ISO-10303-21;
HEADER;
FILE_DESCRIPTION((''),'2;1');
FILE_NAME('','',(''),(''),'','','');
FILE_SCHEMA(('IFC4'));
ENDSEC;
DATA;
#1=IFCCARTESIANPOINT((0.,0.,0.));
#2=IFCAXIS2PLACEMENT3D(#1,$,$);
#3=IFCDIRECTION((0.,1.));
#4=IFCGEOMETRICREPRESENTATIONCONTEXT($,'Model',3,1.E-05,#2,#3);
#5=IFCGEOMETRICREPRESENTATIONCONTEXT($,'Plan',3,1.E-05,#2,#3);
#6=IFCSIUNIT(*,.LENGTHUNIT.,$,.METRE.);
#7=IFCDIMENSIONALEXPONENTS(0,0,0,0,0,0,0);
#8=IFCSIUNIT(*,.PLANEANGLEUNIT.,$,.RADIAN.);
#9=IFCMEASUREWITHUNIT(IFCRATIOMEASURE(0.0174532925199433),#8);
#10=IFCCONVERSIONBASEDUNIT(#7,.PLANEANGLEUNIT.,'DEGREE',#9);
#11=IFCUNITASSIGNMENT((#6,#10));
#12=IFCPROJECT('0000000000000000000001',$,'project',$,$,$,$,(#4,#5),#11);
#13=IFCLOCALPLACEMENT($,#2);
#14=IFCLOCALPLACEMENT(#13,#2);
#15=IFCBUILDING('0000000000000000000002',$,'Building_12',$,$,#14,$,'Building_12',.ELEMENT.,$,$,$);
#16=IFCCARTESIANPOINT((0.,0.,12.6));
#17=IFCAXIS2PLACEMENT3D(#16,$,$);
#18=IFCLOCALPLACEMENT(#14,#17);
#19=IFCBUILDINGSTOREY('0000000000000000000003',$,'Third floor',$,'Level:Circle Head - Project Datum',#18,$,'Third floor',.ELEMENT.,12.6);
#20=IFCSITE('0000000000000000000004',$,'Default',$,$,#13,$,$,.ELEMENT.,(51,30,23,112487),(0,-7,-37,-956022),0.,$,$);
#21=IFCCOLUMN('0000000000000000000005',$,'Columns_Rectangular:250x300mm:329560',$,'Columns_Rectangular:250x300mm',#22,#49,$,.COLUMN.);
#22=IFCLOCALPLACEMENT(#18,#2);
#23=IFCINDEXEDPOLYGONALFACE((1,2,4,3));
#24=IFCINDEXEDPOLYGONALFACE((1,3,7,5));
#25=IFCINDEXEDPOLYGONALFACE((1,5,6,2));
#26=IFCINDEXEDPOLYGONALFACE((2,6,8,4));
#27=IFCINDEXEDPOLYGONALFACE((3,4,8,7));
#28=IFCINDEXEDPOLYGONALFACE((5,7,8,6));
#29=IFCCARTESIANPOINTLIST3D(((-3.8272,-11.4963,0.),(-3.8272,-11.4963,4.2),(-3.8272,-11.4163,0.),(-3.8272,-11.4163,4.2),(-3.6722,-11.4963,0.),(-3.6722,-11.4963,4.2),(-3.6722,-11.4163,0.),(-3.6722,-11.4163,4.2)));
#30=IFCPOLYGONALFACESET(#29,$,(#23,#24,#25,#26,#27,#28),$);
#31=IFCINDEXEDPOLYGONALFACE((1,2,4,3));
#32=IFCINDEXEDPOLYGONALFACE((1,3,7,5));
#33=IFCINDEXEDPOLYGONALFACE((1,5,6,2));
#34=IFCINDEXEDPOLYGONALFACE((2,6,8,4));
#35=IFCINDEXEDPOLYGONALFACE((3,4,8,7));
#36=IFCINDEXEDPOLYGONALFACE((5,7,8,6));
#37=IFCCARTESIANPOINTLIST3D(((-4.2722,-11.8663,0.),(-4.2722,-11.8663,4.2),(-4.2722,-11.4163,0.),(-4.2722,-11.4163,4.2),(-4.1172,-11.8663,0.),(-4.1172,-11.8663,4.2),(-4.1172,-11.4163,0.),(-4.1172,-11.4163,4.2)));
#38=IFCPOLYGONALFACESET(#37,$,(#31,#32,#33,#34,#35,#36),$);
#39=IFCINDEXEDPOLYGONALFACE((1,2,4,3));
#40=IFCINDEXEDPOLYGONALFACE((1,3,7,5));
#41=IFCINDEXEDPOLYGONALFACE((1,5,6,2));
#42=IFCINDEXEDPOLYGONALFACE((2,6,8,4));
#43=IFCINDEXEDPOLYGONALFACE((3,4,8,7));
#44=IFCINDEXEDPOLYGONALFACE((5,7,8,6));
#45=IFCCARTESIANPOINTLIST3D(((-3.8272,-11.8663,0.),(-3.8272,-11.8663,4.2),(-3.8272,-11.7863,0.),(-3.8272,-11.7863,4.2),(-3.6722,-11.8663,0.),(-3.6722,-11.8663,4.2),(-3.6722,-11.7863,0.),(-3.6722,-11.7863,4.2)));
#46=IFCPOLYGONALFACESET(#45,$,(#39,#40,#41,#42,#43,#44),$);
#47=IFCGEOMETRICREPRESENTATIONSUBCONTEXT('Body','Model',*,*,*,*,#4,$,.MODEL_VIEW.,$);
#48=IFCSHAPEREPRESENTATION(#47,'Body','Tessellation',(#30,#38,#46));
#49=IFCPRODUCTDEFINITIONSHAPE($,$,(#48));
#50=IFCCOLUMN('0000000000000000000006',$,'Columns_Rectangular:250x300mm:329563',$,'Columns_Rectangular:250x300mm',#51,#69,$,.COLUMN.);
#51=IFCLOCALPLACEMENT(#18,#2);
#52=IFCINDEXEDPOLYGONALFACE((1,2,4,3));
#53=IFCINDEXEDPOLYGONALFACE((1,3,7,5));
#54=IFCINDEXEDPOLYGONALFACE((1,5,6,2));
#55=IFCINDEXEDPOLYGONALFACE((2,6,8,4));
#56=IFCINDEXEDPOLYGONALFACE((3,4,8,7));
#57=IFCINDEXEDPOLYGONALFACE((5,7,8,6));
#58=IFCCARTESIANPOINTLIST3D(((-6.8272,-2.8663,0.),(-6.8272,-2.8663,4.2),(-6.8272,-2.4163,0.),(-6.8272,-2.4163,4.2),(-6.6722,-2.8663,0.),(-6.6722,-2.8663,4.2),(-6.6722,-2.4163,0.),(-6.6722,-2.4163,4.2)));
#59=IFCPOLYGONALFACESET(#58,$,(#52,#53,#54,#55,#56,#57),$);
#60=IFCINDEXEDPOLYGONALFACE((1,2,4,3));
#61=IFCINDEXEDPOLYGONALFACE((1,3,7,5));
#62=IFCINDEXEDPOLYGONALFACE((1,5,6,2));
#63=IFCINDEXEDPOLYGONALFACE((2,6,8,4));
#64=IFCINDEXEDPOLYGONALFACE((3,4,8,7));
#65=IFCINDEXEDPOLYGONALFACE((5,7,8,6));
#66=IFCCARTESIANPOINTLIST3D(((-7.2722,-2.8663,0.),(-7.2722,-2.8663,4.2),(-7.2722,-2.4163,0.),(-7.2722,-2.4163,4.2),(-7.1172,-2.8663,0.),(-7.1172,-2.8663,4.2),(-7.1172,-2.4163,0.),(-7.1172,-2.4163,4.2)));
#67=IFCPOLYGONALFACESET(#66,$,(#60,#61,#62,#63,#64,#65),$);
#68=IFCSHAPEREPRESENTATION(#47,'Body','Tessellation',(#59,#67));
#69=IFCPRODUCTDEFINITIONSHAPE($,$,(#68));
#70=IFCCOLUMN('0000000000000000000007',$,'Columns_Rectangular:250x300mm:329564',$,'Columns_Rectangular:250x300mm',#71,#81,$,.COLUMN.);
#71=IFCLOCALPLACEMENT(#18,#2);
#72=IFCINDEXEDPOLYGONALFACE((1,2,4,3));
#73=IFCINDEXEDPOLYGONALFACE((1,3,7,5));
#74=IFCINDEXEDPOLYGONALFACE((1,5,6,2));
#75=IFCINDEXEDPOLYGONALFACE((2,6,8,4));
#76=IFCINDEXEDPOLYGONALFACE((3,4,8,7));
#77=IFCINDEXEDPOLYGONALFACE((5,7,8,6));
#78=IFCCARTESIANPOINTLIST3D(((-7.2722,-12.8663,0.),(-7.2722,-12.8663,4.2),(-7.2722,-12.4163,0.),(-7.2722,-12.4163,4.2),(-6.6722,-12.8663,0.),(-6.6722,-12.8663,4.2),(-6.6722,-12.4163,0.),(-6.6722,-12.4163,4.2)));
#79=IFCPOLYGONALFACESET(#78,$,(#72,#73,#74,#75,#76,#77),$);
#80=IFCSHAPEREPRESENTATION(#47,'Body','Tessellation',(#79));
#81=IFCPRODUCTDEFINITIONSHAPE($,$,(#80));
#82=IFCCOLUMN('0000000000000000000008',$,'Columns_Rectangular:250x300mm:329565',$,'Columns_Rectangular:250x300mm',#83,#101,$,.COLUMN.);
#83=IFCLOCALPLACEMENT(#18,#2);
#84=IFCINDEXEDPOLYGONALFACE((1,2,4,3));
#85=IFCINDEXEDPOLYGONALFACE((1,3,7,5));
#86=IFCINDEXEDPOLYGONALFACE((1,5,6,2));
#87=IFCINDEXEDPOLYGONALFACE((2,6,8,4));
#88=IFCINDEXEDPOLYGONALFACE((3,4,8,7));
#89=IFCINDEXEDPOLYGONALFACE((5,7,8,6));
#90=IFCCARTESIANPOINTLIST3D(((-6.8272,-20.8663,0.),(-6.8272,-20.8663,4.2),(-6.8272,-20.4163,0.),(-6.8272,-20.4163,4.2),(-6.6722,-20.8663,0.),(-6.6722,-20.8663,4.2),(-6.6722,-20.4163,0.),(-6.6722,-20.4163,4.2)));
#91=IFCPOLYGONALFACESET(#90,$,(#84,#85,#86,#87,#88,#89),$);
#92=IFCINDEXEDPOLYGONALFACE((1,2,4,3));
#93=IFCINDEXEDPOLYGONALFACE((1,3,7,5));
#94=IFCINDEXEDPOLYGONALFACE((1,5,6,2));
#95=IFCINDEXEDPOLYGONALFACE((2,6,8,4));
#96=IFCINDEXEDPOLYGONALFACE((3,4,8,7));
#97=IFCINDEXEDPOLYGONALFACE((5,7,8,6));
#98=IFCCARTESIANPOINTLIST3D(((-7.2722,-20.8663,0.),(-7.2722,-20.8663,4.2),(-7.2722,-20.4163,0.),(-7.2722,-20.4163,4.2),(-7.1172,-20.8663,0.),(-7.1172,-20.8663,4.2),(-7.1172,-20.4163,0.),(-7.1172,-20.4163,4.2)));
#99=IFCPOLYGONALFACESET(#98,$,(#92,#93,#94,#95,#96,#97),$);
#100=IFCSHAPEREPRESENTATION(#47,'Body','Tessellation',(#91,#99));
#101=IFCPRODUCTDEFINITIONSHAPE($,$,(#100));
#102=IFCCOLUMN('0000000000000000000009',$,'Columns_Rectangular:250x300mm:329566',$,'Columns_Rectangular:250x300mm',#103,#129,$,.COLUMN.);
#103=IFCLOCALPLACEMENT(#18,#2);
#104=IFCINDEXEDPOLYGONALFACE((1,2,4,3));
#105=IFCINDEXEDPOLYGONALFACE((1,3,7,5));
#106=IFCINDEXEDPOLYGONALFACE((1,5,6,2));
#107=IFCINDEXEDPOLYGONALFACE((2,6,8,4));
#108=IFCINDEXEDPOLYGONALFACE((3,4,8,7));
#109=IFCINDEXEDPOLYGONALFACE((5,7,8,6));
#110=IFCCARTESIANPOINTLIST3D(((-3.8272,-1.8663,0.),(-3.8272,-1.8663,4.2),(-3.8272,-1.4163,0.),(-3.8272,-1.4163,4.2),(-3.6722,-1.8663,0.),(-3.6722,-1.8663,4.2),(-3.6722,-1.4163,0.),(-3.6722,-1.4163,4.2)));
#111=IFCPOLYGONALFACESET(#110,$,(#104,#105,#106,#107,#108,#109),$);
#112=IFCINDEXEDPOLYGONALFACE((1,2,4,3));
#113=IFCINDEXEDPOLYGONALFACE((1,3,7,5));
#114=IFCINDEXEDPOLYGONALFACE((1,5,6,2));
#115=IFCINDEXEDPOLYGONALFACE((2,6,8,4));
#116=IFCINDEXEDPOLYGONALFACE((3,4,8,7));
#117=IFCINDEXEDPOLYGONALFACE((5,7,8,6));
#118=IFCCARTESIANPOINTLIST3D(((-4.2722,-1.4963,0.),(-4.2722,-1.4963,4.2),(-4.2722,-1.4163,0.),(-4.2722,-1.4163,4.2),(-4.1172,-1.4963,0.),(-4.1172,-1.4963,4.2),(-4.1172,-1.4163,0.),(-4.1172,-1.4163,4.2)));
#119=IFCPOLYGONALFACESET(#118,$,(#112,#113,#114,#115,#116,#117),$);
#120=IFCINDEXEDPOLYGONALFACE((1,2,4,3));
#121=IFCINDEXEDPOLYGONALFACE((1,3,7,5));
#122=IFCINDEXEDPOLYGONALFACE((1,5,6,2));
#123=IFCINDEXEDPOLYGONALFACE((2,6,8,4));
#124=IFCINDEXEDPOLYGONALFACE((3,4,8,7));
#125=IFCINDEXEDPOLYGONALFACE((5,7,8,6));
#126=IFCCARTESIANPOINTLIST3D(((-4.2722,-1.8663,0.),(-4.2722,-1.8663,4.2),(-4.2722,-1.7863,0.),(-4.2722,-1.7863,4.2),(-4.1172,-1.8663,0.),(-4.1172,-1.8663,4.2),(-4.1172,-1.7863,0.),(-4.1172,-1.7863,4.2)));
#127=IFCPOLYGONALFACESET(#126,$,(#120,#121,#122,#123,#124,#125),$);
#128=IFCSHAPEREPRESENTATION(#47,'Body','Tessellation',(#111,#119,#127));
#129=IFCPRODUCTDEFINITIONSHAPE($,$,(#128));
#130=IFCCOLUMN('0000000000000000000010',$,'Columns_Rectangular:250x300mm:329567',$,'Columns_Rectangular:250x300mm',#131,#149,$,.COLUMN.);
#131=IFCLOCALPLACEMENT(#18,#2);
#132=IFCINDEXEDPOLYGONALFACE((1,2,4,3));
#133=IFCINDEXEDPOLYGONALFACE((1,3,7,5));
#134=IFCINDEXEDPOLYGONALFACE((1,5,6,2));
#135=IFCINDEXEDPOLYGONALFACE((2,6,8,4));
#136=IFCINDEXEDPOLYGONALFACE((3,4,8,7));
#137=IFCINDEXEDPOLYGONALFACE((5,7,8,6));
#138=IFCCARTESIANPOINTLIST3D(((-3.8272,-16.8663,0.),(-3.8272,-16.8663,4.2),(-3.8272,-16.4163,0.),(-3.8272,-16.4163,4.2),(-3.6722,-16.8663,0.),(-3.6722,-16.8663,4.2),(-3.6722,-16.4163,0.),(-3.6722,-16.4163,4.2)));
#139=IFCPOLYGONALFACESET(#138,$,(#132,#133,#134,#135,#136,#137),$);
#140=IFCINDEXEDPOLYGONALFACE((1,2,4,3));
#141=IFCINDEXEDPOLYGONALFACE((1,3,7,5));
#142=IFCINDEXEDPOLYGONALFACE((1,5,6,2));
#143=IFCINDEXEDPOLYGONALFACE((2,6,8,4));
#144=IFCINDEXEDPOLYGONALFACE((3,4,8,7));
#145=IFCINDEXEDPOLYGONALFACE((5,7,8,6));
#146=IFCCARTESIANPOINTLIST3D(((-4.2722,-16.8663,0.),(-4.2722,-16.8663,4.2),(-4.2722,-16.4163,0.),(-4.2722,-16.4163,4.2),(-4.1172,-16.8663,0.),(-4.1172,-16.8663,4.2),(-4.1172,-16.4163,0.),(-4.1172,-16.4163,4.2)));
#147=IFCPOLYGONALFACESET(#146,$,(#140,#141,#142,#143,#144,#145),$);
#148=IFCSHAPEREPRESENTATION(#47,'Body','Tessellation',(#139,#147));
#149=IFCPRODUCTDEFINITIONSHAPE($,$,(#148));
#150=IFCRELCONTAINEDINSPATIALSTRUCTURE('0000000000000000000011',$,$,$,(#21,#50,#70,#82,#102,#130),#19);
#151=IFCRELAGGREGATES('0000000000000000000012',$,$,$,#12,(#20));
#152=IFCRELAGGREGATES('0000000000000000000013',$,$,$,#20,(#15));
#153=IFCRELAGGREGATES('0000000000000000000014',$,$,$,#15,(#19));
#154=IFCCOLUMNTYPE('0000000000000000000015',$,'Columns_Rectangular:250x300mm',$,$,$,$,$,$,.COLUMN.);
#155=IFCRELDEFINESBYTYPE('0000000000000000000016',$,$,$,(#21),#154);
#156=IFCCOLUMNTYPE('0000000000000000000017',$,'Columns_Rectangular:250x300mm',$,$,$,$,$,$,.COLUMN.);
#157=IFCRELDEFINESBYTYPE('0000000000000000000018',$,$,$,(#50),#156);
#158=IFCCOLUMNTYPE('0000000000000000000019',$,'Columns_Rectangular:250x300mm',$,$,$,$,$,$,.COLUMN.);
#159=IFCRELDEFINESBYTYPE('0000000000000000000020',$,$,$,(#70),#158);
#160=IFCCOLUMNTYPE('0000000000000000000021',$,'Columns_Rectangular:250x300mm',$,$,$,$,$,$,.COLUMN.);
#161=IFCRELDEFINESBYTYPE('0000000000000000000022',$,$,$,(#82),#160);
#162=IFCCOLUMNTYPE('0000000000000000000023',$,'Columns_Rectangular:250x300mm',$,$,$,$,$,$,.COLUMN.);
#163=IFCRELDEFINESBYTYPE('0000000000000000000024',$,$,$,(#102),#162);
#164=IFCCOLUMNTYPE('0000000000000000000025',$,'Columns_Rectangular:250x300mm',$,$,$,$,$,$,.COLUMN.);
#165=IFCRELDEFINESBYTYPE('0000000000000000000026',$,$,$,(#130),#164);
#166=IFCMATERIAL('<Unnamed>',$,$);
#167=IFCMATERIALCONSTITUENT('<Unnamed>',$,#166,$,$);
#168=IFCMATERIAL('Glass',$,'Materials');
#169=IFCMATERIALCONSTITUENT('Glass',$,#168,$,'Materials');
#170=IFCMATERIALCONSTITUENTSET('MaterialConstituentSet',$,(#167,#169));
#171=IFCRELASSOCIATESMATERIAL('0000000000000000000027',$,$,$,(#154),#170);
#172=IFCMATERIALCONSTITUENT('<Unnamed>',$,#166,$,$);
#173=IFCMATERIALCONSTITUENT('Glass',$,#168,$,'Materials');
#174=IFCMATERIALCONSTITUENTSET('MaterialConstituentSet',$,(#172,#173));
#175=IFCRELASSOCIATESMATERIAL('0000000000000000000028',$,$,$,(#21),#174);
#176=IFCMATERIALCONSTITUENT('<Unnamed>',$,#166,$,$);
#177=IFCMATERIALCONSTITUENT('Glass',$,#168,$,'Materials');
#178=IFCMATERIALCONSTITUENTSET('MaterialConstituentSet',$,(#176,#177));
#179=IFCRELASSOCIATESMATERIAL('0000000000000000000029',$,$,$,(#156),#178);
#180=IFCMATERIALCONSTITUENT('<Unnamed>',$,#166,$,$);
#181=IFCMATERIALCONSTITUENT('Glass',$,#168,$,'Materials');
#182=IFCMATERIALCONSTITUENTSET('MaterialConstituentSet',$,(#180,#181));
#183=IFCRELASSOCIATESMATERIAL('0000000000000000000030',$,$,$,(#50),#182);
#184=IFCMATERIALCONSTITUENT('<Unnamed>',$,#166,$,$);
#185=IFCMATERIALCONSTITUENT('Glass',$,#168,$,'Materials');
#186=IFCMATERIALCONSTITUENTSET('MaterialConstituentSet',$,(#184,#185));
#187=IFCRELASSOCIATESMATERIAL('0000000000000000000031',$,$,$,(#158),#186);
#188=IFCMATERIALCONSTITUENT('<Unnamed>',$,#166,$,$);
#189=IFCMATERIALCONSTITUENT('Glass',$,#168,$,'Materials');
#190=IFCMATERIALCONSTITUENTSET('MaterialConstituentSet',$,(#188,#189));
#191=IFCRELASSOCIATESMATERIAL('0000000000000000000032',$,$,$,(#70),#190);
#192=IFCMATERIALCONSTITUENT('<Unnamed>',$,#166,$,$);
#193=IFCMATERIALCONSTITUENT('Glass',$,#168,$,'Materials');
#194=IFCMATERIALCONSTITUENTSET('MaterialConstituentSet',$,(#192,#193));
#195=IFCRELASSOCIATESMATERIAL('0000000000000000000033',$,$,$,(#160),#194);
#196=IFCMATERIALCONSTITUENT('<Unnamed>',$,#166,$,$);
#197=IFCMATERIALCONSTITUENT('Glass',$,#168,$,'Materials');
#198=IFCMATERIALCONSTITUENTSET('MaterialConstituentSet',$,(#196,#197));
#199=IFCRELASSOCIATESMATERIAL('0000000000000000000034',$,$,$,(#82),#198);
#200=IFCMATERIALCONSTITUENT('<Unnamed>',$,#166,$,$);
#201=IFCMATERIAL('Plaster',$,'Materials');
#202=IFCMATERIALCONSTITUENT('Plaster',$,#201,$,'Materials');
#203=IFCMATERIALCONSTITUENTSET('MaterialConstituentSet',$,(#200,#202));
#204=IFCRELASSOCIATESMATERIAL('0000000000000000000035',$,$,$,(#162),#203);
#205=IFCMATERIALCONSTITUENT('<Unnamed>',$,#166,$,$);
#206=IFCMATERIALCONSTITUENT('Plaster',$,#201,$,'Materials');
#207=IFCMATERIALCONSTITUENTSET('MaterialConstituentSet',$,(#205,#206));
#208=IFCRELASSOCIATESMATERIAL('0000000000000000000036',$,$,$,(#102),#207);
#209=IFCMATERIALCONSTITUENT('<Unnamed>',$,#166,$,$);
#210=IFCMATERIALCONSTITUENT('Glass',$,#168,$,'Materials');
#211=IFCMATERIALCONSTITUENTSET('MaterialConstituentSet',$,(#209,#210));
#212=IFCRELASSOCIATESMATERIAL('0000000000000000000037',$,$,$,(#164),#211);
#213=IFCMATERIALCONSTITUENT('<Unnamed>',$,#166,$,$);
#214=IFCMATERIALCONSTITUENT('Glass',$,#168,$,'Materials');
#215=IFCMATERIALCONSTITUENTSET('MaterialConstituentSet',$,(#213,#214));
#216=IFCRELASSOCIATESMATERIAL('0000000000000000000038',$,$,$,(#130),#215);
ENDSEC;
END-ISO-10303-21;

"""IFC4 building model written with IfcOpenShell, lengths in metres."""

from ifc_helpers import new_model, entity, si_unit, converted_unit, direction, frame, origin, place, context, subcontext, project, spatial, indexed_curve, outline, extrude, source, transform, mapped, material, constituent, constituent_set, type_object, type_shapes, element, save


model = new_model("IFC4")

# Units and contexts
model_context = context("Model", 3, precision=1e-05, world=origin(), true_north=direction((0.0, 1.0)))
plan_context = context("Plan", 3, precision=1e-05, world=origin(), true_north=direction((0.0, 1.0)))
body_context = subcontext(model_context, "Body", "Model", "MODEL_VIEW")
ifc_project = project(units=[si_unit("LENGTHUNIT", "METRE"), converted_unit("PLANEANGLEUNIT", "DEGREE", entity("IfcRatioMeasure", 0.0174532925199433), si_unit("PLANEANGLEUNIT", "RADIAN"), dimensions=[0, 0, 0, 0, 0, 0, 0])], contexts=[model_context, plan_context])

# Site, building, storey
site_placement = place(None, origin())
site = spatial("IfcSite", under=ifc_project, at=site_placement, Name="Default", CompositionType="ELEMENT", RefLatitude=(51, 30, 23, 112487), RefLongitude=(0, -7, -37, -956022), RefElevation=0.0)
building_placement = place(site_placement, origin())
building = spatial("IfcBuilding", under=site, at=building_placement, Name="Building_12", LongName="Building_12", CompositionType="ELEMENT")
storey_placement = place(building_placement, frame((0.0, 0.0, 12.6)))
storey = spatial("IfcBuildingStorey", under=building, at=storey_placement, Name="Third floor", ObjectType="Level:Circle Head - Project Datum", LongName="Third floor", CompositionType="ELEMENT", Elevation=12.6)

# Columns
ifc_material_1 = material(Name="<Unnamed>")
ifc_constituent_1 = constituent(ifc_material_1, Name="<Unnamed>")
ifc_material_2 = material(Name="Glass", Category="Materials")
ifc_constituent_2 = constituent(ifc_material_2, Name="Glass", Category="Materials")
ifc_constituent_set_1 = constituent_set(constituents=[ifc_constituent_1, ifc_constituent_2], Name="MaterialConstituentSet")
ifc_constituent_3 = constituent(ifc_material_1, Name="<Unnamed>")
ifc_constituent_4 = constituent(ifc_material_2, Name="Glass", Category="Materials")
ifc_constituent_set_2 = constituent_set(constituents=[ifc_constituent_3, ifc_constituent_4], Name="MaterialConstituentSet")
column_type_1 = type_object("IfcColumnType", Name="Columns_Rectangular:250x300mm", PredefinedType="COLUMN", material=ifc_constituent_set_2)
shared_shape_1 = source(origin(), body_context, "Body", "SweptSolid", [
    extrude(outline(indexed_curve([(-0.04, -0.0775), (0.04, -0.0775), (0.04, 0.0775), (-0.04, 0.0775), (-0.04, -0.0775)], self_intersect=False)), frame((-3.7497, -11.4563, 12.6), z_axis=(0.0, 0.0, 1.0), x_axis=(0.0, -1.0, 0.0)), (0.0, 0.0, 1.0), 4.2),
    extrude(outline(indexed_curve([(-0.225, -0.0775), (0.225, -0.0775), (0.225, 0.0775), (-0.225, 0.0775), (-0.225, -0.0775)], self_intersect=False)), frame((-4.1947, -11.6413, 12.6), z_axis=(0.0, 0.0, 1.0), x_axis=(0.0, -1.0, 0.0)), (0.0, 0.0, 1.0), 4.2),
    extrude(outline(indexed_curve([(-0.04, -0.0775), (0.04, -0.0775), (0.04, 0.0775), (-0.04, 0.0775), (-0.04, -0.0775)], self_intersect=False)), frame((-3.7497, -11.8263, 12.6), z_axis=(0.0, 0.0, 1.0), x_axis=(0.0, -1.0, 0.0)), (0.0, 0.0, 1.0), 4.2),
])
type_shapes(column_type_1, [shared_shape_1])
column_1_placement = place(storey_placement, frame((0.0, 0.0, -12.6)))
element("IfcColumn", 1, at=column_1_placement, inside=storey, type_object=column_type_1, material=ifc_constituent_set_1, Name="Columns_Rectangular:250x300mm:329560", ObjectType="Columns_Rectangular:250x300mm", PredefinedType="COLUMN", context=body_context, shape_type="MappedRepresentation", body=[
    mapped(shared_shape_1, transform((0.0, 0.0, 0.0), scale=1.0)),
])
ifc_material_3 = material(Name="Plaster", Category="Materials")
ifc_constituent_5 = constituent(ifc_material_1, Name="<Unnamed>")
ifc_constituent_6 = constituent(ifc_material_2, Name="Glass", Category="Materials")
ifc_constituent_set_3 = constituent_set(constituents=[ifc_constituent_5, ifc_constituent_6], Name="MaterialConstituentSet")
ifc_constituent_7 = constituent(ifc_material_1, Name="<Unnamed>")
ifc_constituent_8 = constituent(ifc_material_2, Name="Glass", Category="Materials")
ifc_constituent_set_4 = constituent_set(constituents=[ifc_constituent_7, ifc_constituent_8], Name="MaterialConstituentSet")
column_type_2 = type_object("IfcColumnType", Name="Columns_Rectangular:250x300mm", PredefinedType="COLUMN", material=ifc_constituent_set_4)
shared_shape_2 = source(origin(), body_context, "Body", "SweptSolid", [
    extrude(outline(indexed_curve([(-0.225, -0.0775), (0.225, -0.0775), (0.225, 0.0775), (-0.225, 0.0775), (-0.225, -0.0775)], self_intersect=False)), frame((-6.7497, -2.6413, 12.6), z_axis=(0.0, 0.0, 1.0), x_axis=(0.0, -1.0, 0.0)), (0.0, 0.0, 1.0), 4.2),
    extrude(outline(indexed_curve([(-0.225, -0.0775), (0.225, -0.0775), (0.225, 0.0775), (-0.225, 0.0775), (-0.225, -0.0775)], self_intersect=False)), frame((-7.1947, -2.6413, 12.6), z_axis=(0.0, 0.0, 1.0), x_axis=(0.0, -1.0, 0.0)), (0.0, 0.0, 1.0), 4.2),
])
type_shapes(column_type_2, [shared_shape_2])
column_2_placement = place(storey_placement, frame((0.0, 0.0, -12.6)))
element("IfcColumn", 2, at=column_2_placement, inside=storey, type_object=column_type_2, material=ifc_constituent_set_3, Name="Columns_Rectangular:250x300mm:329563", ObjectType="Columns_Rectangular:250x300mm", PredefinedType="COLUMN", context=body_context, shape_type="MappedRepresentation", body=[
    mapped(shared_shape_2, transform((0.0, 0.0, 0.0), scale=1.0)),
])
ifc_constituent_9 = constituent(ifc_material_1, Name="<Unnamed>")
ifc_constituent_10 = constituent(ifc_material_2, Name="Glass", Category="Materials")
ifc_constituent_set_5 = constituent_set(constituents=[ifc_constituent_9, ifc_constituent_10], Name="MaterialConstituentSet")
ifc_constituent_11 = constituent(ifc_material_1, Name="<Unnamed>")
ifc_constituent_12 = constituent(ifc_material_2, Name="Glass", Category="Materials")
ifc_constituent_set_6 = constituent_set(constituents=[ifc_constituent_11, ifc_constituent_12], Name="MaterialConstituentSet")
column_type_3 = type_object("IfcColumnType", Name="Columns_Rectangular:250x300mm", PredefinedType="COLUMN", material=ifc_constituent_set_6)
shared_shape_3 = source(origin(), body_context, "Body", "SweptSolid", [
    extrude(outline(indexed_curve([(-0.225, -0.3), (0.225, -0.3), (0.225, 0.3), (-0.225, 0.3), (-0.225, -0.3)], self_intersect=False)), frame((-6.9722, -12.6413, 12.6), z_axis=(0.0, 0.0, 1.0), x_axis=(0.0, -1.0, 0.0)), (0.0, 0.0, 1.0), 4.2),
])
type_shapes(column_type_3, [shared_shape_3])
column_3_placement = place(storey_placement, frame((0.0, 0.0, -12.6)))
element("IfcColumn", 3, at=column_3_placement, inside=storey, type_object=column_type_3, material=ifc_constituent_set_5, Name="Columns_Rectangular:250x300mm:329564", ObjectType="Columns_Rectangular:250x300mm", PredefinedType="COLUMN", context=body_context, shape_type="MappedRepresentation", body=[
    mapped(shared_shape_3, transform((0.0, 0.0, 0.0), scale=1.0)),
])
ifc_constituent_13 = constituent(ifc_material_1, Name="<Unnamed>")
ifc_constituent_14 = constituent(ifc_material_2, Name="Glass", Category="Materials")
ifc_constituent_set_7 = constituent_set(constituents=[ifc_constituent_13, ifc_constituent_14], Name="MaterialConstituentSet")
ifc_constituent_15 = constituent(ifc_material_1, Name="<Unnamed>")
ifc_constituent_16 = constituent(ifc_material_2, Name="Glass", Category="Materials")
ifc_constituent_set_8 = constituent_set(constituents=[ifc_constituent_15, ifc_constituent_16], Name="MaterialConstituentSet")
column_type_4 = type_object("IfcColumnType", Name="Columns_Rectangular:250x300mm", PredefinedType="COLUMN", material=ifc_constituent_set_8)
shared_shape_4 = source(origin(), body_context, "Body", "SweptSolid", [
    extrude(outline(indexed_curve([(-0.225, -0.0775), (0.225, -0.0775), (0.225, 0.0775), (-0.225, 0.0775), (-0.225, -0.0775)], self_intersect=False)), frame((-6.7497, -20.6413, 12.6), z_axis=(0.0, 0.0, 1.0), x_axis=(0.0, -1.0, 0.0)), (0.0, 0.0, 1.0), 4.2),
    extrude(outline(indexed_curve([(-0.225, -0.0775), (0.225, -0.0775), (0.225, 0.0775), (-0.225, 0.0775), (-0.225, -0.0775)], self_intersect=False)), frame((-7.1947, -20.6413, 12.6), z_axis=(0.0, 0.0, 1.0), x_axis=(0.0, -1.0, 0.0)), (0.0, 0.0, 1.0), 4.2),
])
type_shapes(column_type_4, [shared_shape_4])
column_4_placement = place(storey_placement, frame((0.0, 0.0, -12.6)))
element("IfcColumn", 4, at=column_4_placement, inside=storey, type_object=column_type_4, material=ifc_constituent_set_7, Name="Columns_Rectangular:250x300mm:329565", ObjectType="Columns_Rectangular:250x300mm", PredefinedType="COLUMN", context=body_context, shape_type="MappedRepresentation", body=[
    mapped(shared_shape_4, transform((0.0, 0.0, 0.0), scale=1.0)),
])
ifc_constituent_17 = constituent(ifc_material_1, Name="<Unnamed>")
ifc_constituent_18 = constituent(ifc_material_3, Name="Plaster", Category="Materials")
ifc_constituent_set_9 = constituent_set(constituents=[ifc_constituent_17, ifc_constituent_18], Name="MaterialConstituentSet")
ifc_constituent_19 = constituent(ifc_material_1, Name="<Unnamed>")
ifc_constituent_20 = constituent(ifc_material_3, Name="Plaster", Category="Materials")
ifc_constituent_set_10 = constituent_set(constituents=[ifc_constituent_19, ifc_constituent_20], Name="MaterialConstituentSet")
column_type_5 = type_object("IfcColumnType", Name="Columns_Rectangular:250x300mm", PredefinedType="COLUMN", material=ifc_constituent_set_10)
shared_shape_5 = source(origin(), body_context, "Body", "SweptSolid", [
    extrude(outline(indexed_curve([(-0.225, -0.0775), (0.225, -0.0775), (0.225, 0.0775), (-0.225, 0.0775), (-0.225, -0.0775)], self_intersect=False)), frame((-3.7497, -1.6413, 12.6), z_axis=(0.0, 0.0, 1.0), x_axis=(0.0, -1.0, 0.0)), (0.0, 0.0, 1.0), 4.2),
    extrude(outline(indexed_curve([(-0.04, -0.0775), (0.04, -0.0775), (0.04, 0.0775), (-0.04, 0.0775), (-0.04, -0.0775)], self_intersect=False)), frame((-4.1947, -1.4563, 12.6), z_axis=(0.0, 0.0, 1.0), x_axis=(0.0, -1.0, 0.0)), (0.0, 0.0, 1.0), 4.2),
    extrude(outline(indexed_curve([(-0.04, -0.0775), (0.04, -0.0775), (0.04, 0.0775), (-0.04, 0.0775), (-0.04, -0.0775)], self_intersect=False)), frame((-4.1947, -1.8263, 12.6), z_axis=(0.0, 0.0, 1.0), x_axis=(0.0, -1.0, 0.0)), (0.0, 0.0, 1.0), 4.2),
])
type_shapes(column_type_5, [shared_shape_5])
column_5_placement = place(storey_placement, frame((0.0, 0.0, -12.6)))
element("IfcColumn", 5, at=column_5_placement, inside=storey, type_object=column_type_5, material=ifc_constituent_set_9, Name="Columns_Rectangular:250x300mm:329566", ObjectType="Columns_Rectangular:250x300mm", PredefinedType="COLUMN", context=body_context, shape_type="MappedRepresentation", body=[
    mapped(shared_shape_5, transform((0.0, 0.0, 0.0), scale=1.0)),
])
ifc_constituent_21 = constituent(ifc_material_1, Name="<Unnamed>")
ifc_constituent_22 = constituent(ifc_material_2, Name="Glass", Category="Materials")
ifc_constituent_set_11 = constituent_set(constituents=[ifc_constituent_21, ifc_constituent_22], Name="MaterialConstituentSet")
ifc_constituent_23 = constituent(ifc_material_1, Name="<Unnamed>")
ifc_constituent_24 = constituent(ifc_material_2, Name="Glass", Category="Materials")
ifc_constituent_set_12 = constituent_set(constituents=[ifc_constituent_23, ifc_constituent_24], Name="MaterialConstituentSet")
column_type_6 = type_object("IfcColumnType", Name="Columns_Rectangular:250x300mm", PredefinedType="COLUMN", material=ifc_constituent_set_12)
shared_shape_6 = source(origin(), body_context, "Body", "SweptSolid", [
    extrude(outline(indexed_curve([(-0.225, -0.0775), (0.225, -0.0775), (0.225, 0.0775), (-0.225, 0.0775), (-0.225, -0.0775)], self_intersect=False)), frame((-3.7497, -16.6413, 12.6), z_axis=(0.0, 0.0, 1.0), x_axis=(0.0, -1.0, 0.0)), (0.0, 0.0, 1.0), 4.2),
    extrude(outline(indexed_curve([(-0.225, -0.0775), (0.225, -0.0775), (0.225, 0.0775), (-0.225, 0.0775), (-0.225, -0.0775)], self_intersect=False)), frame((-4.1947, -16.6413, 12.6), z_axis=(0.0, 0.0, 1.0), x_axis=(0.0, -1.0, 0.0)), (0.0, 0.0, 1.0), 4.2),
])
type_shapes(column_type_6, [shared_shape_6])
column_6_placement = place(storey_placement, frame((0.0, 0.0, -12.6)))
element("IfcColumn", 6, at=column_6_placement, inside=storey, type_object=column_type_6, material=ifc_constituent_set_11, Name="Columns_Rectangular:250x300mm:329567", ObjectType="Columns_Rectangular:250x300mm", PredefinedType="COLUMN", context=body_context, shape_type="MappedRepresentation", body=[
    mapped(shared_shape_6, transform((0.0, 0.0, 0.0), scale=1.0)),
])

save(model, "model.ifc")
